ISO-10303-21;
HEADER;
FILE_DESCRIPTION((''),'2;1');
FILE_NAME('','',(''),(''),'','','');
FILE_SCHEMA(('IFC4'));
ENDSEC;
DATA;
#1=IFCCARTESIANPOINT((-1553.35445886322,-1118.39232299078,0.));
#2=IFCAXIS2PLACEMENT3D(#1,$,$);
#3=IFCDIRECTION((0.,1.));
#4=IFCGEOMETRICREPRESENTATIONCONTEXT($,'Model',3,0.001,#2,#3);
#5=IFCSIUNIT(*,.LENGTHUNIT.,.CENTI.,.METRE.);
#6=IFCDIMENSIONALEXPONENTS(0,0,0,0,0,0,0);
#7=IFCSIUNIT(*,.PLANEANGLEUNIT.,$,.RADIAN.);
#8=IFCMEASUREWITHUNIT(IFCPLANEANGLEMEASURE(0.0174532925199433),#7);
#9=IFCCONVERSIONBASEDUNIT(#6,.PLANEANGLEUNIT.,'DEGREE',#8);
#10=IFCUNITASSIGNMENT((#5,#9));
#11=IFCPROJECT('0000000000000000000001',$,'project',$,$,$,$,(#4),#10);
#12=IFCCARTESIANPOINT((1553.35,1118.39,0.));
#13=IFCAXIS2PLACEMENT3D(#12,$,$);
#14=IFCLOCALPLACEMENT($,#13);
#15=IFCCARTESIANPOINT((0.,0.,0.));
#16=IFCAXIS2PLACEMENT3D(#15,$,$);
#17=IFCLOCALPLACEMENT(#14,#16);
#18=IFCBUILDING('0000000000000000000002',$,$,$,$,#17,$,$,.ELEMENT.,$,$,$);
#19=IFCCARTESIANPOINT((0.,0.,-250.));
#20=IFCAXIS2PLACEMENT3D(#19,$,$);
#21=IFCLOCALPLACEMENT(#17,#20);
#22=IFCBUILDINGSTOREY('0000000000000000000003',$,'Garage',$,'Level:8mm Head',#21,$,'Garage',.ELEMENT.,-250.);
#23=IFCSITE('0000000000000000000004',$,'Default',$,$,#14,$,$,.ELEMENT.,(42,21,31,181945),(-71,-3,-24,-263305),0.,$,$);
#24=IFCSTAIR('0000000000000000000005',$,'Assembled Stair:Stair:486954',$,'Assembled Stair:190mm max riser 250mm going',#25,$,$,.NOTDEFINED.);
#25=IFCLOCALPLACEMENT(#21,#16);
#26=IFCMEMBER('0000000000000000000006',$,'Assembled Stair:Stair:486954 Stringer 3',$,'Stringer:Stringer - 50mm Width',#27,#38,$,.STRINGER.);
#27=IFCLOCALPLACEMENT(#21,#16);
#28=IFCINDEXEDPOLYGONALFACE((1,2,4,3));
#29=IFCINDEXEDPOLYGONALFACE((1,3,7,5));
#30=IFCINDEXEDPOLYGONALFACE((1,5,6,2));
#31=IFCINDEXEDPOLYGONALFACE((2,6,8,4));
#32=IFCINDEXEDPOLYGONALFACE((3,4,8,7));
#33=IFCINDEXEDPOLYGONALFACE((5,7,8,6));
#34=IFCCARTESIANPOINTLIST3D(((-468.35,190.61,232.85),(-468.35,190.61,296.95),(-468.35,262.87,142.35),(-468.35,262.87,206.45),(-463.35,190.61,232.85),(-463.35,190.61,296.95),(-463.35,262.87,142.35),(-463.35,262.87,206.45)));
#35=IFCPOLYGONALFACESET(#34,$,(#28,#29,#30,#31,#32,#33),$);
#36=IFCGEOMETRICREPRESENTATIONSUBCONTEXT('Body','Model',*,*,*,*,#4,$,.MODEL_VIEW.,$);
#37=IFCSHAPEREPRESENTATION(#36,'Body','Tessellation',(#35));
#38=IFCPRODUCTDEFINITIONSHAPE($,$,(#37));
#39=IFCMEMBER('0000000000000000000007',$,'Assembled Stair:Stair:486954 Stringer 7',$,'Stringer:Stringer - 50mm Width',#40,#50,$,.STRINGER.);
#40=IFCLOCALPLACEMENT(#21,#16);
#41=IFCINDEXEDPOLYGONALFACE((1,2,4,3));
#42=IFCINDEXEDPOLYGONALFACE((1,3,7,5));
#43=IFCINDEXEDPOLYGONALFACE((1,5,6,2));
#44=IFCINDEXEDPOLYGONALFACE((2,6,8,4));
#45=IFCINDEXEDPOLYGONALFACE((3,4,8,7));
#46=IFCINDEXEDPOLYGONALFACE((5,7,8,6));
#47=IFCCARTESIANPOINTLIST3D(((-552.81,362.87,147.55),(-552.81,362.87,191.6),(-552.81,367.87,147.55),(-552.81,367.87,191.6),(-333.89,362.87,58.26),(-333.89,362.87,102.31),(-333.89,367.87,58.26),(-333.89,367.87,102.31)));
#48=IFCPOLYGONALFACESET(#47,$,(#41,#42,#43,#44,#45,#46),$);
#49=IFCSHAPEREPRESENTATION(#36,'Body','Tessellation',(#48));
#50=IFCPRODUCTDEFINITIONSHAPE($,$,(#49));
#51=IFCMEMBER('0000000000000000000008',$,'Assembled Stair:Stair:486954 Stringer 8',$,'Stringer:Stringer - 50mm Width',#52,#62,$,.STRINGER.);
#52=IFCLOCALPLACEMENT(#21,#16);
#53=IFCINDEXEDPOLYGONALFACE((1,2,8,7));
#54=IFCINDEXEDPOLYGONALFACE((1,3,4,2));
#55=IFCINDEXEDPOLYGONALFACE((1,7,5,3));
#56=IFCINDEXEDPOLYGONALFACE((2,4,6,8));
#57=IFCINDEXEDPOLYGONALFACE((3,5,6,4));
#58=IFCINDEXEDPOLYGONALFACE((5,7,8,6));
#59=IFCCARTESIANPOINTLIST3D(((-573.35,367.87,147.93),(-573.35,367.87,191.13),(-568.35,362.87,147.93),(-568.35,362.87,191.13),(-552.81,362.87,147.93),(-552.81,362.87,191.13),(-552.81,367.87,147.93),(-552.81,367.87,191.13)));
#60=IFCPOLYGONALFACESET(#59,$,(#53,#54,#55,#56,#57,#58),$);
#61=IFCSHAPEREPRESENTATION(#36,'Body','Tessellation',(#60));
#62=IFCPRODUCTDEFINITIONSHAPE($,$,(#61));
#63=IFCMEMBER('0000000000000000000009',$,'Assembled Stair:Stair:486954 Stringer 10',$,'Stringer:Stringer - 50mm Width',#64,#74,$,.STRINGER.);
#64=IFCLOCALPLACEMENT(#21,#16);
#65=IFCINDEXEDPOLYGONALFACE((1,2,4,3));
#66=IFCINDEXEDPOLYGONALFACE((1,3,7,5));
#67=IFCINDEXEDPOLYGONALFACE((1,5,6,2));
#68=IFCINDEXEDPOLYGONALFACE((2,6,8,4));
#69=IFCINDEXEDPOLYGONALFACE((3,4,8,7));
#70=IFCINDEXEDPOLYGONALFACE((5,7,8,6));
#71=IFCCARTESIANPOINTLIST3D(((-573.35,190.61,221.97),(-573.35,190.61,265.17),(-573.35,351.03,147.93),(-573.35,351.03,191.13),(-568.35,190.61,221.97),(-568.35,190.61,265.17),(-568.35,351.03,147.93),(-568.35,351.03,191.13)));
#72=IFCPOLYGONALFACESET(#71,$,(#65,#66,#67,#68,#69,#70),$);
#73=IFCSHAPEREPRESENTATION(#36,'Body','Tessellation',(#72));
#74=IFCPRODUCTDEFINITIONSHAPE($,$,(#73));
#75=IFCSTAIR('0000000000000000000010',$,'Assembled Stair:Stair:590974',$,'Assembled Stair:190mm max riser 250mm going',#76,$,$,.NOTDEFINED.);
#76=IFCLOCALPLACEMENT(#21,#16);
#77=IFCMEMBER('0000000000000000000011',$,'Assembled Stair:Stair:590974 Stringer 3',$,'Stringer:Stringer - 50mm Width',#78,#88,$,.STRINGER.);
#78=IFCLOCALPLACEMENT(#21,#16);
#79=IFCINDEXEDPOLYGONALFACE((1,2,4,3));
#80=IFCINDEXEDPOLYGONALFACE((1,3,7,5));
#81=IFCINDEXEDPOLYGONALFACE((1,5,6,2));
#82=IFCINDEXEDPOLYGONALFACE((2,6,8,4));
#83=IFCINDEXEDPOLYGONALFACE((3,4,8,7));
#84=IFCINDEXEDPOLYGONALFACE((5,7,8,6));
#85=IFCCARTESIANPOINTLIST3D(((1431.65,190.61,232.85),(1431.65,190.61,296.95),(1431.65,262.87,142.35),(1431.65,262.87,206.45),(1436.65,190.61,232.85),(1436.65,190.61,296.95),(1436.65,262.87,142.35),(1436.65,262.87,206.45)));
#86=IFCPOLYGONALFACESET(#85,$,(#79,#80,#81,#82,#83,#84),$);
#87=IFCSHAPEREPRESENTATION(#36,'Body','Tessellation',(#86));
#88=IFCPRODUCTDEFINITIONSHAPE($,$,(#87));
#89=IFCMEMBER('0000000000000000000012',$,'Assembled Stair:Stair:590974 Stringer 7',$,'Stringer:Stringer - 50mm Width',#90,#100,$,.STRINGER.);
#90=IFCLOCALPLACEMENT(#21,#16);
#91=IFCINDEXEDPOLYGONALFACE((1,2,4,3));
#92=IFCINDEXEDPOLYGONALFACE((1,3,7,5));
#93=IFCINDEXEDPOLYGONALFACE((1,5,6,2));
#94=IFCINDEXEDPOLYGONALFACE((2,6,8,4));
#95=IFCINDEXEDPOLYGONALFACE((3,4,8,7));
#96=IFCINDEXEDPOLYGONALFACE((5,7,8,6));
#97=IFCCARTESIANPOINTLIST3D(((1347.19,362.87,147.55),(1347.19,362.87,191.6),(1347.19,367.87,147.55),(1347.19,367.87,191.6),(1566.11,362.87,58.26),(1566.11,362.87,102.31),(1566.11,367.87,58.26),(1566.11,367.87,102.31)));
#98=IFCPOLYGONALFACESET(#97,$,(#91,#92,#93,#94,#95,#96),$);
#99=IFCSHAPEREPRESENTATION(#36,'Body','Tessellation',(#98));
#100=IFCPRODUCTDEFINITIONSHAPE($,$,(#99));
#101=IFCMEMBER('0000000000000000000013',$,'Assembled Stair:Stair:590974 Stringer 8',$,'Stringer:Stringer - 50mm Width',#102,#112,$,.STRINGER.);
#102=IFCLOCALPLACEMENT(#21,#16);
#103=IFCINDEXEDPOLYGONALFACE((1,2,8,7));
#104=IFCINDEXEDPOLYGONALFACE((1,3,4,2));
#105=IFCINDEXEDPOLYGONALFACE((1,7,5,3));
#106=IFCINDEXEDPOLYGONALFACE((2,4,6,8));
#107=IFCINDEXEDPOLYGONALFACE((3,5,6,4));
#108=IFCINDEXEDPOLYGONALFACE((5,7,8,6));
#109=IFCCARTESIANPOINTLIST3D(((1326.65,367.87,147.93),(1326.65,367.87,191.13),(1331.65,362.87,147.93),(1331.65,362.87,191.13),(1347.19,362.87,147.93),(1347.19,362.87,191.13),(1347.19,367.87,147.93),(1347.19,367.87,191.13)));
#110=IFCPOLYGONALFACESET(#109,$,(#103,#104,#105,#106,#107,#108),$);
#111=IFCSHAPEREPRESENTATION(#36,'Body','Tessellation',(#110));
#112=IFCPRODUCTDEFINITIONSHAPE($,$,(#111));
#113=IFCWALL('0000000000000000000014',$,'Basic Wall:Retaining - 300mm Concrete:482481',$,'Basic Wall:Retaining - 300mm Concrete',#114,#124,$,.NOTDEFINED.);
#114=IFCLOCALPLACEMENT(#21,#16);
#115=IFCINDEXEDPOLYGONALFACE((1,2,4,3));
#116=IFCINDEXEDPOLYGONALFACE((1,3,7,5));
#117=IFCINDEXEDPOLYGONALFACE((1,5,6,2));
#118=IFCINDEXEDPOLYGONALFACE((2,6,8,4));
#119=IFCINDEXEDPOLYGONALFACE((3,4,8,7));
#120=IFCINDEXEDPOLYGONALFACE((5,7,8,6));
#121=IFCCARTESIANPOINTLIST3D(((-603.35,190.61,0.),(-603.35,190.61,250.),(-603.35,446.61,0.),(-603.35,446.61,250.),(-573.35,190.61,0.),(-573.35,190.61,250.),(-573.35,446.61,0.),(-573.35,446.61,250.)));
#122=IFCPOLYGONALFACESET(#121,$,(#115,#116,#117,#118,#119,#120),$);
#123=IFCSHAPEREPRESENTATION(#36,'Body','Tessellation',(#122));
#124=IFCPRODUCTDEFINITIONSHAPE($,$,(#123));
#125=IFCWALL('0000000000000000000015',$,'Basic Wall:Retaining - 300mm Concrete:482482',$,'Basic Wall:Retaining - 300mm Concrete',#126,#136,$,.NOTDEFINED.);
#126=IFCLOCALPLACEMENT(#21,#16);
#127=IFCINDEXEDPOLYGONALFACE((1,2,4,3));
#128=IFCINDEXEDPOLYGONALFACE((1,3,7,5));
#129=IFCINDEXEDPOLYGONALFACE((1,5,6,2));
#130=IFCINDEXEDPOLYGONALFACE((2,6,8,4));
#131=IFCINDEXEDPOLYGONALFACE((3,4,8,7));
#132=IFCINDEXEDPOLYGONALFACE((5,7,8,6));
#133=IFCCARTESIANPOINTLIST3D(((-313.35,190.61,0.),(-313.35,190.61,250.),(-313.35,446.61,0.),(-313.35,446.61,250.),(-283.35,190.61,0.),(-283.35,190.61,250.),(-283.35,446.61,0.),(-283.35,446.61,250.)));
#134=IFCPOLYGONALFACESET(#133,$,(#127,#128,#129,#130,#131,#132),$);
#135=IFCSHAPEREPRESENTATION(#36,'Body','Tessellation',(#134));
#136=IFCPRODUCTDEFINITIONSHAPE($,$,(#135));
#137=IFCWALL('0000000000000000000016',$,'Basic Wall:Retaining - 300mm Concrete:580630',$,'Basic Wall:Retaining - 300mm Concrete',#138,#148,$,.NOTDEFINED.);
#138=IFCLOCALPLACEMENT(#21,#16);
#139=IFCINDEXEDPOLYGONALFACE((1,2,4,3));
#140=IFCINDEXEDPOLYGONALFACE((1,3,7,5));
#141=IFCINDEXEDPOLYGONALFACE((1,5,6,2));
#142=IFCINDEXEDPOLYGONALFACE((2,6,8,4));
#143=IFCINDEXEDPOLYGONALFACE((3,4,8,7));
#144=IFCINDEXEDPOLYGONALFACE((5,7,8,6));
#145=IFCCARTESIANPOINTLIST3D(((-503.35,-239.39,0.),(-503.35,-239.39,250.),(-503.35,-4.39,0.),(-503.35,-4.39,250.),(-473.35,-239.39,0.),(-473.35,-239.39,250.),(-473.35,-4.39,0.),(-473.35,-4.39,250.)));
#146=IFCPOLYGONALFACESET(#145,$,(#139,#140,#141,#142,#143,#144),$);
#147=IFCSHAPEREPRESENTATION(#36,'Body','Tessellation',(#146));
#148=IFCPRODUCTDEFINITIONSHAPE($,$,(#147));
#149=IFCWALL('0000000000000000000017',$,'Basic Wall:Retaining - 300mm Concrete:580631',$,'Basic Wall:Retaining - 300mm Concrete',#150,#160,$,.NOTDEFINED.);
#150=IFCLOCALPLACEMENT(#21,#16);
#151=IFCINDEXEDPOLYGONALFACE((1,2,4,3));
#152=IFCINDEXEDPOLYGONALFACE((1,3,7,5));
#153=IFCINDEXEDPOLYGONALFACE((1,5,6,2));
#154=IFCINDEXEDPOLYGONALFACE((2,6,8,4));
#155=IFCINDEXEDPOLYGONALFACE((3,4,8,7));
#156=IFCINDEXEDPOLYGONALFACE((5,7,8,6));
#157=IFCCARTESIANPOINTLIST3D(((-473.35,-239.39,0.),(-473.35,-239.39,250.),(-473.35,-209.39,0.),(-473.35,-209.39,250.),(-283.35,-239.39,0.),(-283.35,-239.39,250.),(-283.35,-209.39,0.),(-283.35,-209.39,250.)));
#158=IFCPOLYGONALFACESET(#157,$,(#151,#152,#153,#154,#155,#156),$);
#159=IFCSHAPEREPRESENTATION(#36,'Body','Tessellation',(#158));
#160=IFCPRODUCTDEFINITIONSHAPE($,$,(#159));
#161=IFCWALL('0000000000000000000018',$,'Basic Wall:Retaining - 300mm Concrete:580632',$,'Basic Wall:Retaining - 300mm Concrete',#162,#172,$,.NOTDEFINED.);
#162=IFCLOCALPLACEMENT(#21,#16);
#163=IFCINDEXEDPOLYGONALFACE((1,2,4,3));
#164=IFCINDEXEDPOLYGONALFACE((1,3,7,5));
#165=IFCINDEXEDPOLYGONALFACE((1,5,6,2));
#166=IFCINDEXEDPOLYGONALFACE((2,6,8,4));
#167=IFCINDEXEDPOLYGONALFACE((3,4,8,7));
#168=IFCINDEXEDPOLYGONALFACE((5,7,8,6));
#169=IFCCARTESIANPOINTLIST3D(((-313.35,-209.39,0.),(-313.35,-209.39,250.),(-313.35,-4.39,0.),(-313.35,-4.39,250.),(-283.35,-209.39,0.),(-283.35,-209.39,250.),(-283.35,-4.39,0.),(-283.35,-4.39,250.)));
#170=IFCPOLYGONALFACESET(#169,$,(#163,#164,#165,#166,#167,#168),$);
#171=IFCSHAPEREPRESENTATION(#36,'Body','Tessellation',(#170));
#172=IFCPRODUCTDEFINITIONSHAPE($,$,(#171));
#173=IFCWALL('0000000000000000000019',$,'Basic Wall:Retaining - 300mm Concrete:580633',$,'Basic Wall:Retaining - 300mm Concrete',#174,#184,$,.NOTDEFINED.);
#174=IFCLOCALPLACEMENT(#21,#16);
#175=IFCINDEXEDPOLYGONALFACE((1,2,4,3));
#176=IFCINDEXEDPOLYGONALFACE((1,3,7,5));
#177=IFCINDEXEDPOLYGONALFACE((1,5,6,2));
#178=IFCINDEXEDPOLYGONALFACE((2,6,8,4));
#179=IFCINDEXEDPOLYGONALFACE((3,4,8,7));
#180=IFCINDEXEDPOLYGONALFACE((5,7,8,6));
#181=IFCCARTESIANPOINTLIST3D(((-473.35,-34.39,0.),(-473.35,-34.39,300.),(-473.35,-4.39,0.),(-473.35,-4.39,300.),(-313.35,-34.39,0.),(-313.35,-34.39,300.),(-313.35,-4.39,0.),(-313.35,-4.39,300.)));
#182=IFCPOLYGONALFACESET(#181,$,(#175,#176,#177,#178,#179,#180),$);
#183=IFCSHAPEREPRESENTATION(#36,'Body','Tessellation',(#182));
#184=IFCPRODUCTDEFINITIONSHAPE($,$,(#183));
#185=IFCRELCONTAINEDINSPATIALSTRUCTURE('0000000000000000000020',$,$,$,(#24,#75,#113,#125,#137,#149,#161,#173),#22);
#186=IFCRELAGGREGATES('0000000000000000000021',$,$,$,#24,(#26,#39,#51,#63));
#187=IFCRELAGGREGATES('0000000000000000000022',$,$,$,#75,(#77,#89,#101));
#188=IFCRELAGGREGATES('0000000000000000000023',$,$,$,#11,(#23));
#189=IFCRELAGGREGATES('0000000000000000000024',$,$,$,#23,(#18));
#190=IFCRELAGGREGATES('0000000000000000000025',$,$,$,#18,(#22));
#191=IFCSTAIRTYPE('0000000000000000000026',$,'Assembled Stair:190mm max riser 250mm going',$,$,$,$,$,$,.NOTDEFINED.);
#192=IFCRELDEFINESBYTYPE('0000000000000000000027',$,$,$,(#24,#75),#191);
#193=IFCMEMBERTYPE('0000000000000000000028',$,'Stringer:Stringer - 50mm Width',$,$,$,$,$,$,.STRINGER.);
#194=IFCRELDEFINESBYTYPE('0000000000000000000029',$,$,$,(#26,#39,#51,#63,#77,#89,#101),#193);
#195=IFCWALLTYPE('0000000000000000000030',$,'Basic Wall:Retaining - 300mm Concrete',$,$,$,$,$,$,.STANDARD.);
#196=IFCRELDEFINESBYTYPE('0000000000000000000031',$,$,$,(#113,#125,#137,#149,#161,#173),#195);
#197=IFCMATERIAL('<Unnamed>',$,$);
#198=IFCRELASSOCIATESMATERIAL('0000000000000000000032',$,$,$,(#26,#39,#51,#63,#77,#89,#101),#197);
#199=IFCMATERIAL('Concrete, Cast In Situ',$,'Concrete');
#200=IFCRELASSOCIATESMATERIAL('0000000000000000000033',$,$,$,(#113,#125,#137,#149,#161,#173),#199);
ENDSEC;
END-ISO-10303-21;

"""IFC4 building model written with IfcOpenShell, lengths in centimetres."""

from ifc_helpers import new_model, entity, si_unit, converted_unit, direction, frame, origin, place, context, subcontext, project, spatial, indexed_curve, outline, extrude, material, type_object, element, aggregate, save


model = new_model("IFC4")

# Units and contexts
model_context = context("Model", 3, precision=0.001, world=frame((-1553.35445886322, -1118.39232299078, 0.0)), true_north=direction((0.0, 1.0)))
body_context = subcontext(model_context, "Body", "Model", "MODEL_VIEW")
ifc_project = project(units=[si_unit("LENGTHUNIT", "METRE", prefix="CENTI"), converted_unit("PLANEANGLEUNIT", "DEGREE", entity("IfcPlaneAngleMeasure", 0.0174532925199433), si_unit("PLANEANGLEUNIT", "RADIAN"), dimensions=[0, 0, 0, 0, 0, 0, 0])], contexts=[model_context])

# Site, building, storey
site_placement = place(None, frame((1553.35, 1118.39, 0.0)))
site = spatial("IfcSite", under=ifc_project, at=site_placement, Name="Default", CompositionType="ELEMENT", RefLatitude=(42, 21, 31, 181945), RefLongitude=(-71, -3, -24, -263305), RefElevation=0.0)
building_placement = place(site_placement, origin())
building = spatial("IfcBuilding", under=site, at=building_placement, CompositionType="ELEMENT")
storey_placement = place(building_placement, frame((0.0, 0.0, -250.0)))
storey = spatial("IfcBuildingStorey", under=building, at=storey_placement, Name="Garage", ObjectType="Level:8mm Head", LongName="Garage", CompositionType="ELEMENT", Elevation=-250.0)

# Stairs, members
stair_type = type_object("IfcStairType", Name="Assembled Stair:190mm max riser 250mm going", PredefinedType="NOTDEFINED")
stair_1_placement = place(storey_placement, origin())
stair_1 = element("IfcStair", 1, at=stair_1_placement, inside=storey, type_object=stair_type, Name="Assembled Stair:Stair:486954", ObjectType="Assembled Stair:190mm max riser 250mm going", PredefinedType="NOTDEFINED")
ifc_material_1 = material(Name="<Unnamed>")
member_type = type_object("IfcMemberType", Name="Stringer:Stringer - 50mm Width", PredefinedType="STRINGER")
member_1_placement = place(stair_1_placement, origin())
member_1 = element("IfcMember", 2, at=member_1_placement, type_object=member_type, material=ifc_material_1, Name="Assembled Stair:Stair:486954 Stringer 3", ObjectType="Stringer:Stringer - 50mm Width", PredefinedType="STRINGER", context=body_context, shape_type="SweptSolid", body=[
    extrude(outline(indexed_curve([(-32.86, -20.0), (82.95, -20.0), (32.86, 20.0), (-82.95, 20.0), (-32.86, -20.0)], self_intersect=False)), frame((-468.35, 226.74, 219.65), z_axis=(1.0, 0.0, 0.0), x_axis=(0.0, -0.623994, 0.781429)), (0.0, 0.0, 1.0), 5.0),
])
member_2_placement = place(stair_1_placement, origin())
member_2 = element("IfcMember", 3, at=member_2_placement, type_object=member_type, material=ifc_material_1, Name="Assembled Stair:Stair:486954 Stringer 7", ObjectType="Stringer:Stringer - 50mm Width", PredefinedType="STRINGER", context=body_context, shape_type="SweptSolid", body=[
    extrude(outline(indexed_curve([(-126.53, -20.4), (109.9, -20.4), (126.53, 20.4), (-109.9, 20.4), (-126.53, -20.4)], self_intersect=False)), frame((-443.35, 362.87, 124.93), z_axis=(0.0, 1.0, 0.0), x_axis=(-0.92595, 0.0, 0.377646)), (0.0, 0.0, 1.0), 5.0),
])
member_3_placement = place(stair_1_placement, origin())
member_3 = element("IfcMember", 4, at=member_3_placement, type_object=member_type, material=ifc_material_1, Name="Assembled Stair:Stair:486954 Stringer 8", ObjectType="Stringer:Stringer - 50mm Width", PredefinedType="STRINGER", context=body_context, shape_type="SweptSolid", body=[
    extrude(outline(indexed_curve([(-9.02, -2.5), (11.52, -2.5), (6.52, 2.5), (-9.02, 2.5), (-9.02, -2.5)], self_intersect=False)), frame((-561.83, 365.37, 147.93), z_axis=(0.0, 0.0, 1.0), x_axis=(-1.0, 0.0, 0.0)), (0.0, 0.0, 1.0), 43.2),
])
member_4_placement = place(stair_1_placement, origin())
member_4 = element("IfcMember", 5, at=member_4_placement, type_object=member_type, material=ifc_material_1, Name="Assembled Stair:Stair:486954 Stringer 10", ObjectType="Stringer:Stringer - 50mm Width", PredefinedType="STRINGER", context=body_context, shape_type="SweptSolid", body=[
    extrude(outline(indexed_curve([(-79.29, -19.61), (97.39, -19.61), (79.29, 19.61), (-97.39, 19.61), (-79.29, -19.61)], self_intersect=False)), frame((-573.35, 270.82, 206.55), z_axis=(1.0, 0.0, 0.0), x_axis=(0.0, -0.907966, 0.419043)), (0.0, 0.0, 1.0), 5.0),
])
stair_2_placement = place(storey_placement, origin())
stair_2 = element("IfcStair", 6, at=stair_2_placement, inside=storey, type_object=stair_type, Name="Assembled Stair:Stair:590974", ObjectType="Assembled Stair:190mm max riser 250mm going", PredefinedType="NOTDEFINED")
member_5_placement = place(stair_2_placement, origin())
member_5 = element("IfcMember", 7, at=member_5_placement, type_object=member_type, material=ifc_material_1, Name="Assembled Stair:Stair:590974 Stringer 3", ObjectType="Stringer:Stringer - 50mm Width", PredefinedType="STRINGER", context=body_context, shape_type="SweptSolid", body=[
    extrude(outline(indexed_curve([(-32.86, -20.0), (82.95, -20.0), (32.86, 20.0), (-82.95, 20.0), (-32.86, -20.0)], self_intersect=False)), frame((1431.65, 226.74, 219.65), z_axis=(1.0, 0.0, 0.0), x_axis=(0.0, -0.623994, 0.781429)), (0.0, 0.0, 1.0), 5.0),
])
member_6_placement = place(stair_2_placement, origin())
member_6 = element("IfcMember", 8, at=member_6_placement, type_object=member_type, material=ifc_material_1, Name="Assembled Stair:Stair:590974 Stringer 7", ObjectType="Stringer:Stringer - 50mm Width", PredefinedType="STRINGER", context=body_context, shape_type="SweptSolid", body=[
    extrude(outline(indexed_curve([(-126.53, -20.4), (109.9, -20.4), (126.53, 20.4), (-109.9, 20.4), (-126.53, -20.4)], self_intersect=False)), frame((1456.65, 362.87, 124.93), z_axis=(0.0, 1.0, 0.0), x_axis=(-0.92595, 0.0, 0.377646)), (0.0, 0.0, 1.0), 5.0),
])
member_7_placement = place(stair_2_placement, origin())
member_7 = element("IfcMember", 9, at=member_7_placement, type_object=member_type, material=ifc_material_1, Name="Assembled Stair:Stair:590974 Stringer 8", ObjectType="Stringer:Stringer - 50mm Width", PredefinedType="STRINGER", context=body_context, shape_type="SweptSolid", body=[
    extrude(outline(indexed_curve([(-9.02, -2.5), (11.52, -2.5), (6.52, 2.5), (-9.02, 2.5), (-9.02, -2.5)], self_intersect=False)), frame((1338.17, 365.37, 147.93), z_axis=(0.0, 0.0, 1.0), x_axis=(-1.0, 0.0, 0.0)), (0.0, 0.0, 1.0), 43.2),
])

# Walls
ifc_material_2 = material(Name="Concrete, Cast In Situ", Category="Concrete")
wall_type_1 = type_object("IfcWallType", Name="Basic Wall:Retaining - 300mm Concrete", PredefinedType="STANDARD")
wall_1_placement = place(storey_placement, frame((-588.35, 446.61, 0.0), z_axis=(0.0, 0.0, 1.0), x_axis=(0.0, -1.0, 0.0)))
element("IfcWall", 10, at=wall_1_placement, inside=storey, type_object=wall_type_1, material=ifc_material_2, Name="Basic Wall:Retaining - 300mm Concrete:482481", ObjectType="Basic Wall:Retaining - 300mm Concrete", PredefinedType="NOTDEFINED", context=body_context, shape_type="SweptSolid", body=[
    extrude(outline(indexed_curve([(256.0, 15.0), (0.0, 15.0), (0.0, -15.0), (256.0, -15.0), (256.0, 15.0)], self_intersect=False)), origin(), (0.0, 0.0, 1.0), 250.0),
])
wall_2_placement = place(storey_placement, frame((-298.35, 446.61, 0.0), z_axis=(0.0, 0.0, 1.0), x_axis=(0.0, -1.0, 0.0)))
element("IfcWall", 11, at=wall_2_placement, inside=storey, type_object=wall_type_1, material=ifc_material_2, Name="Basic Wall:Retaining - 300mm Concrete:482482", ObjectType="Basic Wall:Retaining - 300mm Concrete", PredefinedType="NOTDEFINED", context=body_context, shape_type="SweptSolid", body=[
    extrude(outline(indexed_curve([(256.0, 15.0), (0.0, 15.0), (0.0, -15.0), (256.0, -15.0), (256.0, 15.0)], self_intersect=False)), origin(), (0.0, 0.0, 1.0), 250.0),
])
wall_3_placement = place(storey_placement, frame((-488.35, -4.39, 0.0), z_axis=(0.0, 0.0, 1.0), x_axis=(0.0, -1.0, 0.0)))
element("IfcWall", 12, at=wall_3_placement, inside=storey, type_object=wall_type_1, material=ifc_material_2, Name="Basic Wall:Retaining - 300mm Concrete:580630", ObjectType="Basic Wall:Retaining - 300mm Concrete", PredefinedType="NOTDEFINED", context=body_context, shape_type="SweptSolid", body=[
    extrude(outline(indexed_curve([(235.0, 15.0), (0.0, 15.0), (0.0, -15.0), (235.0, -15.0), (235.0, 15.0)], self_intersect=False)), origin(), (0.0, 0.0, 1.0), 250.0),
])
wall_4_placement = place(storey_placement, frame((-473.35, -224.39, 0.0)))
element("IfcWall", 13, at=wall_4_placement, inside=storey, type_object=wall_type_1, material=ifc_material_2, Name="Basic Wall:Retaining - 300mm Concrete:580631", ObjectType="Basic Wall:Retaining - 300mm Concrete", PredefinedType="NOTDEFINED", context=body_context, shape_type="SweptSolid", body=[
    extrude(outline(indexed_curve([(190.0, 15.0), (0.0, 15.0), (0.0, -15.0), (190.0, -15.0), (190.0, 15.0)], self_intersect=False)), origin(), (0.0, 0.0, 1.0), 250.0),
])
wall_5_placement = place(storey_placement, frame((-298.35, -209.39, 0.0), z_axis=(0.0, 0.0, 1.0), x_axis=(0.0, 1.0, 0.0)))
element("IfcWall", 14, at=wall_5_placement, inside=storey, type_object=wall_type_1, material=ifc_material_2, Name="Basic Wall:Retaining - 300mm Concrete:580632", ObjectType="Basic Wall:Retaining - 300mm Concrete", PredefinedType="NOTDEFINED", context=body_context, shape_type="SweptSolid", body=[
    extrude(outline(indexed_curve([(205.0, 15.0), (0.0, 15.0), (0.0, -15.0), (205.0, -15.0), (205.0, 15.0)], self_intersect=False)), origin(), (0.0, 0.0, 1.0), 250.0),
])
wall_6_placement = place(storey_placement, frame((-313.35, -19.39, 0.0), z_axis=(0.0, 0.0, 1.0), x_axis=(-1.0, 0.0, 0.0)))
element("IfcWall", 15, at=wall_6_placement, inside=storey, type_object=wall_type_1, material=ifc_material_2, Name="Basic Wall:Retaining - 300mm Concrete:580633", ObjectType="Basic Wall:Retaining - 300mm Concrete", PredefinedType="NOTDEFINED", context=body_context, shape_type="SweptSolid", body=[
    extrude(outline(indexed_curve([(160.0, 15.0), (0.0, 15.0), (0.0, -15.0), (160.0, -15.0), (160.0, 15.0)], self_intersect=False)), origin(), (0.0, 0.0, 1.0), 300.0),
])

aggregate(stair_1, [member_1, member_2, member_3, member_4])
aggregate(stair_2, [member_5, member_6, member_7])

save(model, "model.ifc")
